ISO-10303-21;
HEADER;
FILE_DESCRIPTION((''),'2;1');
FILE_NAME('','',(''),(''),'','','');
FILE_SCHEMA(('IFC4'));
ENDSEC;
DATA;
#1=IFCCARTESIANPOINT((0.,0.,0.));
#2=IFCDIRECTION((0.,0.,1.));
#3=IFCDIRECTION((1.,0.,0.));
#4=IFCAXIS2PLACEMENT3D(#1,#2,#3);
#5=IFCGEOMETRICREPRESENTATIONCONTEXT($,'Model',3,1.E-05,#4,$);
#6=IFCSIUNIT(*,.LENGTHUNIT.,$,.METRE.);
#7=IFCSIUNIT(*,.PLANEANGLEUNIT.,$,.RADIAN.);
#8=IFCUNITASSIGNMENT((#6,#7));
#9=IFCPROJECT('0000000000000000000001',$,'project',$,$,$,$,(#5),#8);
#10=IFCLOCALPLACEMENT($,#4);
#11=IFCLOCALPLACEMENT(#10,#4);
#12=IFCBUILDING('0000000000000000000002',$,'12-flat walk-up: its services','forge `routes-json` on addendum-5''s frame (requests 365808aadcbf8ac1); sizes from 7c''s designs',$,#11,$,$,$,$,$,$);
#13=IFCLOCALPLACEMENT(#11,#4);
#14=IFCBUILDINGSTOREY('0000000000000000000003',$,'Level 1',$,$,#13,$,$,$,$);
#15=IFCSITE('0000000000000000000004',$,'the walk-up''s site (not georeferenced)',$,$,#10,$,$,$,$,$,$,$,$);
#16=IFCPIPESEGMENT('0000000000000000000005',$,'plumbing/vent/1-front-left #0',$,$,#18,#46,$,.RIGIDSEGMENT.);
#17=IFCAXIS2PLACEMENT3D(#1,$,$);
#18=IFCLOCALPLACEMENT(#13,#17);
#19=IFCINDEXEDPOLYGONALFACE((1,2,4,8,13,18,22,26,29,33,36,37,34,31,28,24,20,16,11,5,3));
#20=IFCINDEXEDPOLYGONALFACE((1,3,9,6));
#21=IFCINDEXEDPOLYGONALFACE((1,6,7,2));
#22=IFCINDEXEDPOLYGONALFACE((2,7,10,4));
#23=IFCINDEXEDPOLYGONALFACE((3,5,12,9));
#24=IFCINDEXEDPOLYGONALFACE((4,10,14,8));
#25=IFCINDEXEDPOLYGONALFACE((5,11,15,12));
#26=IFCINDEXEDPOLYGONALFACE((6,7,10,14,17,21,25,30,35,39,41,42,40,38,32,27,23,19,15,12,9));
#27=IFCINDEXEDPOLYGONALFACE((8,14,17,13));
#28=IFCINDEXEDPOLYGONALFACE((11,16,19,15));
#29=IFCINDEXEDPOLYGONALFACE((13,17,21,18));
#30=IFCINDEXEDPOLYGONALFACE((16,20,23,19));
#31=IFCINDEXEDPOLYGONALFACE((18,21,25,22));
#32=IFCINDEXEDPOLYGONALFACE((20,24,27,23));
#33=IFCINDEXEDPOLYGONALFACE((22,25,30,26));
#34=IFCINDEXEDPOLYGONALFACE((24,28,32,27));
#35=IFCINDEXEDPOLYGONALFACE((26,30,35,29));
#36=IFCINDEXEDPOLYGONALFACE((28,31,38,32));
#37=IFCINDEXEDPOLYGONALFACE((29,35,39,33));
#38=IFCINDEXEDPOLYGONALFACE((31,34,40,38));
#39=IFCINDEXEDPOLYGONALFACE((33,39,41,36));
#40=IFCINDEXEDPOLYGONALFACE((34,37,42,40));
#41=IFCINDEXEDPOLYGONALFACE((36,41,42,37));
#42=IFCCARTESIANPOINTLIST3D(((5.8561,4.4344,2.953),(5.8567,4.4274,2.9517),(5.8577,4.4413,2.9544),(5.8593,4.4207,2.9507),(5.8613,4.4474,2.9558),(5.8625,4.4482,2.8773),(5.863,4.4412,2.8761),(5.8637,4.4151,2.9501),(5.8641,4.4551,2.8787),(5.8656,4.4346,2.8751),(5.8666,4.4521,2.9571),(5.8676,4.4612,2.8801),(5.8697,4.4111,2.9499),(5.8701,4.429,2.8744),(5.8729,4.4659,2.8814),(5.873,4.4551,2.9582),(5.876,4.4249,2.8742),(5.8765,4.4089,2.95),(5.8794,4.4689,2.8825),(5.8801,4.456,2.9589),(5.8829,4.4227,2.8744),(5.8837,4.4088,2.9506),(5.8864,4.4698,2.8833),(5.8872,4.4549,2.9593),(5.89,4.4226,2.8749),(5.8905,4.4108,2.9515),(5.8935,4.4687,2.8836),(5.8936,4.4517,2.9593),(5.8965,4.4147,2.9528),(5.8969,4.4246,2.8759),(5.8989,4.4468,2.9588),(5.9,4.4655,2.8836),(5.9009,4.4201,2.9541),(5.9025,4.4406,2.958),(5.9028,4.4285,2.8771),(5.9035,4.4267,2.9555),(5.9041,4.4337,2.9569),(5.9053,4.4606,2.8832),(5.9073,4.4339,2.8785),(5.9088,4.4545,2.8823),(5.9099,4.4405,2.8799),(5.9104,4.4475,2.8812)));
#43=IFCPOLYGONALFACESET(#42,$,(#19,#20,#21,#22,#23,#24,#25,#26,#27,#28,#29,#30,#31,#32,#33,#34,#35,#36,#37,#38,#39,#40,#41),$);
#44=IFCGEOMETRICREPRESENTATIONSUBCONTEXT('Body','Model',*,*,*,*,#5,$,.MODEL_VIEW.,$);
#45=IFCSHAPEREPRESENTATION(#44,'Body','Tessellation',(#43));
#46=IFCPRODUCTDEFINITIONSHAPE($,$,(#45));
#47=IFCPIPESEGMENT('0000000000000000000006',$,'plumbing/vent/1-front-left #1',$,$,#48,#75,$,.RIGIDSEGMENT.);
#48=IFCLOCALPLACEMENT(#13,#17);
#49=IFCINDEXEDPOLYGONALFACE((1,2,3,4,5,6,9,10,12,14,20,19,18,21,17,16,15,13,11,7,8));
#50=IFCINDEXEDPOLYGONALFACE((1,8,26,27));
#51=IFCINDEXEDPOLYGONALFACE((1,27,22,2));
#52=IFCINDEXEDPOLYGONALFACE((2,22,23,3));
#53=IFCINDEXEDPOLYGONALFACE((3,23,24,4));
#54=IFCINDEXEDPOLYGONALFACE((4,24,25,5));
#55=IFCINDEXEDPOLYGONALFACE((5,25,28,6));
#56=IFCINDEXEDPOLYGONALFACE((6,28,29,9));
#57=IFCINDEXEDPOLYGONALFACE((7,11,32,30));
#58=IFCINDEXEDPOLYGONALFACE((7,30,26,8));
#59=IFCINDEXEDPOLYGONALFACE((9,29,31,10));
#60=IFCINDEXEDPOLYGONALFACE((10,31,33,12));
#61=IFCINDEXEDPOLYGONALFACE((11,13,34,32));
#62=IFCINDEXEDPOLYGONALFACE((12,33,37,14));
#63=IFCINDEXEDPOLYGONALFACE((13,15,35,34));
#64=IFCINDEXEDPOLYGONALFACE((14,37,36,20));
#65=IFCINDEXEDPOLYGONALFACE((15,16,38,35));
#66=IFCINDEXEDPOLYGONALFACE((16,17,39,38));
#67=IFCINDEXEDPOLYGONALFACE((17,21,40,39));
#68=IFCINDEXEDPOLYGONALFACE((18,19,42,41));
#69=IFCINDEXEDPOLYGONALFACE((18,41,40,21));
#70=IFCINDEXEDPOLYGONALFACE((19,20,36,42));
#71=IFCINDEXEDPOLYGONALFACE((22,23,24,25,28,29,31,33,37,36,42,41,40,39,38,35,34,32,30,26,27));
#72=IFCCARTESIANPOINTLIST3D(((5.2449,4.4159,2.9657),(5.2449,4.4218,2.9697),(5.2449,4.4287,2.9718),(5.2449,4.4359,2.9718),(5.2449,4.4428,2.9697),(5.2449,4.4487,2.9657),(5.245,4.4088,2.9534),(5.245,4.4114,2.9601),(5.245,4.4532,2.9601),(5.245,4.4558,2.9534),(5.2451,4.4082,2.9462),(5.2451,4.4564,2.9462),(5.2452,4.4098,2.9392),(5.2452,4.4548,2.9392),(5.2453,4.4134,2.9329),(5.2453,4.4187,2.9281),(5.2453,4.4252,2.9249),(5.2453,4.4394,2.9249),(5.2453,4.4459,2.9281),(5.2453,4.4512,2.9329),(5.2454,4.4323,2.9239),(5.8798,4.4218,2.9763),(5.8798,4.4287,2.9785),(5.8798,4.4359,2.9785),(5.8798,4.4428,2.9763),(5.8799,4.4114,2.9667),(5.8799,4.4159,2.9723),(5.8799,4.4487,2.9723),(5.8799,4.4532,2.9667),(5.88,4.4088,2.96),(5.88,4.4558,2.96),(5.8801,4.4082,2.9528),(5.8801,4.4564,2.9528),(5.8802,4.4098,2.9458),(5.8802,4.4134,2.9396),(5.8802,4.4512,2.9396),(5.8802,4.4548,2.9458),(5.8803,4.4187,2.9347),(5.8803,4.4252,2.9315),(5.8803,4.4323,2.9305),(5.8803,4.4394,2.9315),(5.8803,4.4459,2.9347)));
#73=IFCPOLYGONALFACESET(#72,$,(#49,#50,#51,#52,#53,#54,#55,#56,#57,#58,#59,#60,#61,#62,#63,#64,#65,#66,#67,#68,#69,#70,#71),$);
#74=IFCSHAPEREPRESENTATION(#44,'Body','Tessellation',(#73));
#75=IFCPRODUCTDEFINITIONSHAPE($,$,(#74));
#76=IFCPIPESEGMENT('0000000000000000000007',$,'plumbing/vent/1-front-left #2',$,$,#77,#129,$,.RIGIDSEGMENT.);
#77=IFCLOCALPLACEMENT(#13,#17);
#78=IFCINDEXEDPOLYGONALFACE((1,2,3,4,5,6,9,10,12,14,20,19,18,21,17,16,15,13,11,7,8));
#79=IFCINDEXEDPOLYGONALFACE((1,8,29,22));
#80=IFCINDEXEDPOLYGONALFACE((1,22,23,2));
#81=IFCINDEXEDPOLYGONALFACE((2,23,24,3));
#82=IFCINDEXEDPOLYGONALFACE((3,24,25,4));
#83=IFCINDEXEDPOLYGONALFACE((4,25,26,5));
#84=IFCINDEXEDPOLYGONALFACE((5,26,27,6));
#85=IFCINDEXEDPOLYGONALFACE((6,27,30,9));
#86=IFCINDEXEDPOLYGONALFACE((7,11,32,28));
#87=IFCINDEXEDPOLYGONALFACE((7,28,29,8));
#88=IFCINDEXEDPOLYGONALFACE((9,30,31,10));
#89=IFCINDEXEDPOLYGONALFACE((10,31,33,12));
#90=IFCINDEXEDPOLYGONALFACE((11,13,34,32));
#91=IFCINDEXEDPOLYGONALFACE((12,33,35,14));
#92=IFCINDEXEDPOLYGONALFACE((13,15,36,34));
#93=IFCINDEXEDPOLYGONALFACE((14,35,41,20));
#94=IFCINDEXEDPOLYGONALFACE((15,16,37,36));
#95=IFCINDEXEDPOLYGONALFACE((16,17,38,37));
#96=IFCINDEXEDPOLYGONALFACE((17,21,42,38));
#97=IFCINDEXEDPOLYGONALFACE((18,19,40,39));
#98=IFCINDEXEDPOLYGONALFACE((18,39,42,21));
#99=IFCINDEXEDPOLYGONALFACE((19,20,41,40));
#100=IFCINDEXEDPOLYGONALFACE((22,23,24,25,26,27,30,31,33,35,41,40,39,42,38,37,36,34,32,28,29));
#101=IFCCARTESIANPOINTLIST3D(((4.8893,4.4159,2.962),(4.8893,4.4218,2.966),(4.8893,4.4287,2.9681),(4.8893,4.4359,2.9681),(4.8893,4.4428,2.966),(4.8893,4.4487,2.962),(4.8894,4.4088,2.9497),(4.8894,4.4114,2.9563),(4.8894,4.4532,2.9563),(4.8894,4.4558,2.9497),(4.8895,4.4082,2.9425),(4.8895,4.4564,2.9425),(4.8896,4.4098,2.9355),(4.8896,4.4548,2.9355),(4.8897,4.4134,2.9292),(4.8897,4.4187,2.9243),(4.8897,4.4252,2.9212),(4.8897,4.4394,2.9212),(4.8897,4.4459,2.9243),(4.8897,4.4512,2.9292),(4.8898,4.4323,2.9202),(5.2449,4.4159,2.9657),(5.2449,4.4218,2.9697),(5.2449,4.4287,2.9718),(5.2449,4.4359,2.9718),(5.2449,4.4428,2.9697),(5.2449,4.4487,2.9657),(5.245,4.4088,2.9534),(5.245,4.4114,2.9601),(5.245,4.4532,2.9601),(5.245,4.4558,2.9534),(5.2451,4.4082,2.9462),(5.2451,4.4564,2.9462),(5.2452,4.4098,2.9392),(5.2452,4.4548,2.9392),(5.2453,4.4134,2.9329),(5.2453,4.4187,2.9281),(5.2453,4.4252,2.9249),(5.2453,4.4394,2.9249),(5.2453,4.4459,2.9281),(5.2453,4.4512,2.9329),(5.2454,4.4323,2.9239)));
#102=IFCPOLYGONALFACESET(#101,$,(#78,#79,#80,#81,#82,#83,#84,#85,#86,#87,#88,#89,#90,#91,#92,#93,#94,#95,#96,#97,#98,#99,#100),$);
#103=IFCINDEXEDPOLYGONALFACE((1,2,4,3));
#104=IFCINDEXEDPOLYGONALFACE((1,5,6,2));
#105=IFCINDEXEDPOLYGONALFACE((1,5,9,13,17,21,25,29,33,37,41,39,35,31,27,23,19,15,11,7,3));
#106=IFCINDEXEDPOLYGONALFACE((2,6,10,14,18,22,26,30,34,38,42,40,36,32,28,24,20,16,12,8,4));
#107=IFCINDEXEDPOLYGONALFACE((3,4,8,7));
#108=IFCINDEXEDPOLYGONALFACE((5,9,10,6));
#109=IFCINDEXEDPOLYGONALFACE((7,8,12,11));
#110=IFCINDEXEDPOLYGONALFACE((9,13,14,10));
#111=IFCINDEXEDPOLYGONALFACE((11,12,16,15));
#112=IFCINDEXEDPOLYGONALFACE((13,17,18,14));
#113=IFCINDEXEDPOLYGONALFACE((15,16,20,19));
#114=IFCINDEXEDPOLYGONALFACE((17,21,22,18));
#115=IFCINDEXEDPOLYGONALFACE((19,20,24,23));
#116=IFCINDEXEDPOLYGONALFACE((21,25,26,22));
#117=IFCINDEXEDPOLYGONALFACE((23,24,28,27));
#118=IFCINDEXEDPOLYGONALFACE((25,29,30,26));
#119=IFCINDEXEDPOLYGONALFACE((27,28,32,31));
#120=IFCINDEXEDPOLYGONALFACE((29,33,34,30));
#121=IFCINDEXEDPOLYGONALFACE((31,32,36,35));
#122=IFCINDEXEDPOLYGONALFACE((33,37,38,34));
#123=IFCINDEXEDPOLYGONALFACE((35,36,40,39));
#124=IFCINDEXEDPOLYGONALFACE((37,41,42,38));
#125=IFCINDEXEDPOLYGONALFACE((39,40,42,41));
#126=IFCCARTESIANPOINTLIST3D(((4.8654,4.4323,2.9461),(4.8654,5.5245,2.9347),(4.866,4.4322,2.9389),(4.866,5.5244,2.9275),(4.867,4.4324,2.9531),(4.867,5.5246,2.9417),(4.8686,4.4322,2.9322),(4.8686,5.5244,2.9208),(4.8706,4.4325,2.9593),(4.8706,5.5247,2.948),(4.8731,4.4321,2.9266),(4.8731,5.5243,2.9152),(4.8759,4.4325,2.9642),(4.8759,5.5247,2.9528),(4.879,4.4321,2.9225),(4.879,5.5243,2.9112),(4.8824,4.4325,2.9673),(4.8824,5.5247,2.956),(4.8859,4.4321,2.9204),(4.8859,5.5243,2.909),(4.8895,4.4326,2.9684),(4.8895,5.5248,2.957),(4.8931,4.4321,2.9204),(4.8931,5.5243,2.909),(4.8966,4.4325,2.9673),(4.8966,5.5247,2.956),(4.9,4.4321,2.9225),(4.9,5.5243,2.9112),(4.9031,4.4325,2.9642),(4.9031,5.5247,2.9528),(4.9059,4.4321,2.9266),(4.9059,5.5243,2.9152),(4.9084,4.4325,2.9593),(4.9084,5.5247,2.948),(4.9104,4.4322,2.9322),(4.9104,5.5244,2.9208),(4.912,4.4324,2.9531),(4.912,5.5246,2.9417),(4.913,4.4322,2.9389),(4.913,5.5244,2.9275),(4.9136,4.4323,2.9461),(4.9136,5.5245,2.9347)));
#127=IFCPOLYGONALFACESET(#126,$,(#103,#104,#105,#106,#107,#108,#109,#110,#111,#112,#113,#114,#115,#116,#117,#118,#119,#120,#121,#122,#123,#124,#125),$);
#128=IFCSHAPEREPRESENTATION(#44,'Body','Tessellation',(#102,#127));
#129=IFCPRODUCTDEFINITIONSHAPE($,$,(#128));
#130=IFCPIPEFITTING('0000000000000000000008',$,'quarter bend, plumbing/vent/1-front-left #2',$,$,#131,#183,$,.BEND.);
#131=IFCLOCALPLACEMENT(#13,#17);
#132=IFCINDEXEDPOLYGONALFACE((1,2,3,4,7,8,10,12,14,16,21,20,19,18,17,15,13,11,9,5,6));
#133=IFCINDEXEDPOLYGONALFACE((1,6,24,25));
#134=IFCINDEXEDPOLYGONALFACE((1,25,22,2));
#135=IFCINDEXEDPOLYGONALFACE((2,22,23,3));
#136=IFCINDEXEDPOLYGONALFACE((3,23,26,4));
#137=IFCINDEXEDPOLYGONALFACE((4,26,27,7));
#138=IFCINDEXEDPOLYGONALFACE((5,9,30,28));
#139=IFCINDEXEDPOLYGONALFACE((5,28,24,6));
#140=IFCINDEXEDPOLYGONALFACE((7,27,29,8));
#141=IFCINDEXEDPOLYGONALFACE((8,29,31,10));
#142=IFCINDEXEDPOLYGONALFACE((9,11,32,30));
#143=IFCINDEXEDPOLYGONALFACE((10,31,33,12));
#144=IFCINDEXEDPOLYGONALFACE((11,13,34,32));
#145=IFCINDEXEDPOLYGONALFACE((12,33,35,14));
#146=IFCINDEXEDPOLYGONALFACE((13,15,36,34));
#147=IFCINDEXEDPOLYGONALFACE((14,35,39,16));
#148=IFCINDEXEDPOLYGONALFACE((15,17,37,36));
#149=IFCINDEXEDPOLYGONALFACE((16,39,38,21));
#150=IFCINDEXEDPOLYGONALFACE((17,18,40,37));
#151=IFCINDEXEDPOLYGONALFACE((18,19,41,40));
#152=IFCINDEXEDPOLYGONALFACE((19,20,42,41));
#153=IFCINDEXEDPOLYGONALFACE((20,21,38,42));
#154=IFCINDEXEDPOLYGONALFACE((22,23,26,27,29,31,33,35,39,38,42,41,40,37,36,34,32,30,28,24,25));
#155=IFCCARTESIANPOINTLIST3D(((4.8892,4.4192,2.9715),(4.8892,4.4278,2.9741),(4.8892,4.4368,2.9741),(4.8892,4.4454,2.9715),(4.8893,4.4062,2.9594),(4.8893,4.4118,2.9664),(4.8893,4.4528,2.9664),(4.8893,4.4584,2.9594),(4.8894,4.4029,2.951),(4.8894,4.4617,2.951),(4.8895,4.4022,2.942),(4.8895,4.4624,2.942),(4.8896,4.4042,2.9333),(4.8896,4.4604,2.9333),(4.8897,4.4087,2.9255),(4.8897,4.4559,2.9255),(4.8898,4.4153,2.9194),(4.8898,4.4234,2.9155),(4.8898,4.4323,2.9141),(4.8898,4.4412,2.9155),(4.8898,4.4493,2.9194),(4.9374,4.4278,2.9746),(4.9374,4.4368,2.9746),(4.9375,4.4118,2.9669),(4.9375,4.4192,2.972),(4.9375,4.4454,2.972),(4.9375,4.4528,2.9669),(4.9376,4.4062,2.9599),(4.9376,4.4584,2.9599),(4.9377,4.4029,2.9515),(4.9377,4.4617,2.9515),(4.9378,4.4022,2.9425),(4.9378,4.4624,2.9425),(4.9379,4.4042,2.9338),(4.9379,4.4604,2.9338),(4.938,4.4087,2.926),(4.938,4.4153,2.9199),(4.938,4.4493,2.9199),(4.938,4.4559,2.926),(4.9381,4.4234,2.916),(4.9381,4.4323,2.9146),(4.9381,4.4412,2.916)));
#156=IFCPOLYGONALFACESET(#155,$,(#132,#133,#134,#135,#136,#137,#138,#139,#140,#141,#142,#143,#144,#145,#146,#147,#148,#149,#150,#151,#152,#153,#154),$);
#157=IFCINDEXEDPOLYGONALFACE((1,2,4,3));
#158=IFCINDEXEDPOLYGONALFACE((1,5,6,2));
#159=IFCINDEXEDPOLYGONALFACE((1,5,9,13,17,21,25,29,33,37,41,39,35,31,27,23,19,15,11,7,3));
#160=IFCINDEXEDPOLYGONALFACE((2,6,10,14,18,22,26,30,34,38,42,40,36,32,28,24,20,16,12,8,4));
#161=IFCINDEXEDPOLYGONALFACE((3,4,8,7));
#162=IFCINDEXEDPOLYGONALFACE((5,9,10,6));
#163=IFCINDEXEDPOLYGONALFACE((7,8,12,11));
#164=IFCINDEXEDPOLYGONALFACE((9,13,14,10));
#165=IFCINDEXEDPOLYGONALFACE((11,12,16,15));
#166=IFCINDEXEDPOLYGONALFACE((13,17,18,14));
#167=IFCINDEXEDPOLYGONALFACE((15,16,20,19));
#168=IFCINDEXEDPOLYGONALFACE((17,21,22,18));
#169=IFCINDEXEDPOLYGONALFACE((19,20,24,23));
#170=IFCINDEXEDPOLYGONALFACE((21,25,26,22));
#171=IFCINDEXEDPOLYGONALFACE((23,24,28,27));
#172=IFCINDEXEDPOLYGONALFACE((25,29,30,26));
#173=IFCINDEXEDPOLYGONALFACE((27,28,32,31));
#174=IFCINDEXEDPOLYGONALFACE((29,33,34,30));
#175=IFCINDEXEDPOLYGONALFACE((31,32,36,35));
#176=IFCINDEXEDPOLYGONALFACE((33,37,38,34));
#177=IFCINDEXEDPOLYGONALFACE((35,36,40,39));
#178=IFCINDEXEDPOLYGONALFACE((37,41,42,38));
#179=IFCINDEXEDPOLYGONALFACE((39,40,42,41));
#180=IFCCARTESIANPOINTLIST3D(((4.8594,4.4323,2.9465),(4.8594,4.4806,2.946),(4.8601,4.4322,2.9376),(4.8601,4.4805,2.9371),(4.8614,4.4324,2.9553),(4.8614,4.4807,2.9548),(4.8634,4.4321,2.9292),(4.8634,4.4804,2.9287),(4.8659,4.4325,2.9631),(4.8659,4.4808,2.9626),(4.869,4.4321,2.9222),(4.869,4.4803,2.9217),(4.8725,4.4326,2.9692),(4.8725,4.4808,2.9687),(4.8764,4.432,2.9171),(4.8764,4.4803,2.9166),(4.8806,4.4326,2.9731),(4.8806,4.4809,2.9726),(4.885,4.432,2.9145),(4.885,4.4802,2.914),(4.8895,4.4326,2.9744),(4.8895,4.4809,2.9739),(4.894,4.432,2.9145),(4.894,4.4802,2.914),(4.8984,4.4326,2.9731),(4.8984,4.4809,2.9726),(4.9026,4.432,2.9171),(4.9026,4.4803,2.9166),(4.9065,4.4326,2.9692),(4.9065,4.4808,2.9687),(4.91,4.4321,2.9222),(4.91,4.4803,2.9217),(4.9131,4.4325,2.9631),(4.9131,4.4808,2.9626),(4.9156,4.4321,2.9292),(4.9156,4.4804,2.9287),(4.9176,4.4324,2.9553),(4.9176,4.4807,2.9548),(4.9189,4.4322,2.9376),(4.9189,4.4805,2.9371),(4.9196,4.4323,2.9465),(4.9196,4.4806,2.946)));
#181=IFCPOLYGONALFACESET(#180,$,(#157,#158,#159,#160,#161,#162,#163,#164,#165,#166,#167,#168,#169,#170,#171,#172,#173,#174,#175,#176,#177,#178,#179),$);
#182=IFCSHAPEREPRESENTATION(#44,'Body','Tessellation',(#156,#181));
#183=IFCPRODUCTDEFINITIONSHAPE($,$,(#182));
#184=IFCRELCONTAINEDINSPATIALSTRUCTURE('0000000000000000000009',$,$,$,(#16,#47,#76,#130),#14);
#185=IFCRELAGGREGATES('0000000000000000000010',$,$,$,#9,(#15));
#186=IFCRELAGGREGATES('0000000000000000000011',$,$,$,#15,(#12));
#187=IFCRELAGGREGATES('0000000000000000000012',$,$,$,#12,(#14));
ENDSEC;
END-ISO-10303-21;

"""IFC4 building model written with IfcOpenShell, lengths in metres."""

from ifc_helpers import new_model, entity, si_unit, frame, origin_with_axes, place, context, subcontext, project, spatial, element, save


model = new_model("IFC4")

# Units and contexts
model_context = context("Model", 3, precision=1e-05, world=origin_with_axes())
body_context = subcontext(model_context, "Body", "Model", "MODEL_VIEW")
ifc_project = project(units=[si_unit("LENGTHUNIT", "METRE"), si_unit("PLANEANGLEUNIT", "RADIAN")], contexts=[model_context])

# Site, building, storey
site_placement = place(None, origin_with_axes())
site = spatial("IfcSite", under=ifc_project, at=site_placement, Name="the walk-up's site (not georeferenced)")
building_placement = place(site_placement, origin_with_axes())
building = spatial("IfcBuilding", under=site, at=building_placement, Name="12-flat walk-up: its services", Description="forge `routes-json` on addendum-5's frame (requests 365808aadcbf8ac1); sizes from 7c's designs")
storey_placement = place(building_placement, origin_with_axes())
storey = spatial("IfcBuildingStorey", under=building, at=storey_placement, Name="Level 1")

# Pipe segments
pipe_segment_1_placement = place(storey_placement, frame((5.8864, 4.4461, 2.8789), z_axis=(0.0, 0.0, 1.0), x_axis=(1.0, 0.0, 0.0)))
element("IfcPipeSegment", 1, at=pipe_segment_1_placement, inside=storey, Name="plumbing/vent/1-front-left #0", PredefinedType="RIGIDSEGMENT", context=body_context, shape_type="AdvancedSweptSolid", body=[
    entity("IfcSweptDiskSolid", entity("IfcPolyline", [entity("IfcCartesianPoint", [0.0, 0.0, 0.0]), entity("IfcCartesianPoint", [-0.0064, -0.0138, 0.0757])]), 0.0241),
    entity("IfcSweptDiskSolid", entity("IfcPolyline", [entity("IfcCartesianPoint", [-0.0064, -0.0138, 0.0757]), entity("IfcCartesianPoint", [-0.0064, -0.0138, 0.0757])]), 0.0241),
])
pipe_segment_2_placement = place(storey_placement, frame((5.8801, 4.4323, 2.9546), z_axis=(0.0, 0.0, 1.0), x_axis=(1.0, 0.0, 0.0)))
element("IfcPipeSegment", 2, at=pipe_segment_2_placement, inside=storey, Name="plumbing/vent/1-front-left #1", PredefinedType="RIGIDSEGMENT", context=body_context, shape_type="AdvancedSweptSolid", body=[
    entity("IfcSweptDiskSolid", entity("IfcPolyline", [entity("IfcCartesianPoint", [0.0, 0.0, 0.0]), entity("IfcCartesianPoint", [-0.635, 0.0, -0.0066])]), 0.0241),
])
pipe_segment_3_placement = place(storey_placement, frame((5.2451, 4.4323, 2.948), z_axis=(0.0, 0.0, 1.0), x_axis=(1.0, 0.0, 0.0)))
element("IfcPipeSegment", 3, at=pipe_segment_3_placement, inside=storey, Name="plumbing/vent/1-front-left #2", PredefinedType="RIGIDSEGMENT", context=body_context, shape_type="AdvancedSweptSolid", body=[
    entity("IfcSweptDiskSolid", entity("IfcPolyline", [entity("IfcCartesianPoint", [0.0, 0.0, 0.0]), entity("IfcCartesianPoint", [-0.3556, 0.0, -0.0037])]), 0.0241),
    entity("IfcSweptDiskSolid", entity("IfcPolyline", [entity("IfcCartesianPoint", [-0.3556, 0.0, -0.0037]), entity("IfcCartesianPoint", [-0.3556, 1.0922, -0.0151])]), 0.0241),
])

# Pipe fitting
pipe_fitting_1_placement = place(storey_placement, frame((4.9378, 4.4323, 2.9448), z_axis=(0.0, 0.0, 1.0), x_axis=(1.0, 0.0, 0.0)))
element("IfcPipeFitting", 4, at=pipe_fitting_1_placement, inside=storey, Name="quarter bend, plumbing/vent/1-front-left #2", PredefinedType="BEND", context=body_context, shape_type="AdvancedSweptSolid", body=[
    entity("IfcSweptDiskSolid", entity("IfcPolyline", [entity("IfcCartesianPoint", [0.0, 0.0, 0.0]), entity("IfcCartesianPoint", [-0.0483, 0.0, -0.0005])]), 0.0302),
    entity("IfcSweptDiskSolid", entity("IfcPolyline", [entity("IfcCartesianPoint", [-0.0483, 0.0, -0.0005]), entity("IfcCartesianPoint", [-0.0483, 0.0483, -0.001])]), 0.0302),
])

save(model, "model.ifc")
